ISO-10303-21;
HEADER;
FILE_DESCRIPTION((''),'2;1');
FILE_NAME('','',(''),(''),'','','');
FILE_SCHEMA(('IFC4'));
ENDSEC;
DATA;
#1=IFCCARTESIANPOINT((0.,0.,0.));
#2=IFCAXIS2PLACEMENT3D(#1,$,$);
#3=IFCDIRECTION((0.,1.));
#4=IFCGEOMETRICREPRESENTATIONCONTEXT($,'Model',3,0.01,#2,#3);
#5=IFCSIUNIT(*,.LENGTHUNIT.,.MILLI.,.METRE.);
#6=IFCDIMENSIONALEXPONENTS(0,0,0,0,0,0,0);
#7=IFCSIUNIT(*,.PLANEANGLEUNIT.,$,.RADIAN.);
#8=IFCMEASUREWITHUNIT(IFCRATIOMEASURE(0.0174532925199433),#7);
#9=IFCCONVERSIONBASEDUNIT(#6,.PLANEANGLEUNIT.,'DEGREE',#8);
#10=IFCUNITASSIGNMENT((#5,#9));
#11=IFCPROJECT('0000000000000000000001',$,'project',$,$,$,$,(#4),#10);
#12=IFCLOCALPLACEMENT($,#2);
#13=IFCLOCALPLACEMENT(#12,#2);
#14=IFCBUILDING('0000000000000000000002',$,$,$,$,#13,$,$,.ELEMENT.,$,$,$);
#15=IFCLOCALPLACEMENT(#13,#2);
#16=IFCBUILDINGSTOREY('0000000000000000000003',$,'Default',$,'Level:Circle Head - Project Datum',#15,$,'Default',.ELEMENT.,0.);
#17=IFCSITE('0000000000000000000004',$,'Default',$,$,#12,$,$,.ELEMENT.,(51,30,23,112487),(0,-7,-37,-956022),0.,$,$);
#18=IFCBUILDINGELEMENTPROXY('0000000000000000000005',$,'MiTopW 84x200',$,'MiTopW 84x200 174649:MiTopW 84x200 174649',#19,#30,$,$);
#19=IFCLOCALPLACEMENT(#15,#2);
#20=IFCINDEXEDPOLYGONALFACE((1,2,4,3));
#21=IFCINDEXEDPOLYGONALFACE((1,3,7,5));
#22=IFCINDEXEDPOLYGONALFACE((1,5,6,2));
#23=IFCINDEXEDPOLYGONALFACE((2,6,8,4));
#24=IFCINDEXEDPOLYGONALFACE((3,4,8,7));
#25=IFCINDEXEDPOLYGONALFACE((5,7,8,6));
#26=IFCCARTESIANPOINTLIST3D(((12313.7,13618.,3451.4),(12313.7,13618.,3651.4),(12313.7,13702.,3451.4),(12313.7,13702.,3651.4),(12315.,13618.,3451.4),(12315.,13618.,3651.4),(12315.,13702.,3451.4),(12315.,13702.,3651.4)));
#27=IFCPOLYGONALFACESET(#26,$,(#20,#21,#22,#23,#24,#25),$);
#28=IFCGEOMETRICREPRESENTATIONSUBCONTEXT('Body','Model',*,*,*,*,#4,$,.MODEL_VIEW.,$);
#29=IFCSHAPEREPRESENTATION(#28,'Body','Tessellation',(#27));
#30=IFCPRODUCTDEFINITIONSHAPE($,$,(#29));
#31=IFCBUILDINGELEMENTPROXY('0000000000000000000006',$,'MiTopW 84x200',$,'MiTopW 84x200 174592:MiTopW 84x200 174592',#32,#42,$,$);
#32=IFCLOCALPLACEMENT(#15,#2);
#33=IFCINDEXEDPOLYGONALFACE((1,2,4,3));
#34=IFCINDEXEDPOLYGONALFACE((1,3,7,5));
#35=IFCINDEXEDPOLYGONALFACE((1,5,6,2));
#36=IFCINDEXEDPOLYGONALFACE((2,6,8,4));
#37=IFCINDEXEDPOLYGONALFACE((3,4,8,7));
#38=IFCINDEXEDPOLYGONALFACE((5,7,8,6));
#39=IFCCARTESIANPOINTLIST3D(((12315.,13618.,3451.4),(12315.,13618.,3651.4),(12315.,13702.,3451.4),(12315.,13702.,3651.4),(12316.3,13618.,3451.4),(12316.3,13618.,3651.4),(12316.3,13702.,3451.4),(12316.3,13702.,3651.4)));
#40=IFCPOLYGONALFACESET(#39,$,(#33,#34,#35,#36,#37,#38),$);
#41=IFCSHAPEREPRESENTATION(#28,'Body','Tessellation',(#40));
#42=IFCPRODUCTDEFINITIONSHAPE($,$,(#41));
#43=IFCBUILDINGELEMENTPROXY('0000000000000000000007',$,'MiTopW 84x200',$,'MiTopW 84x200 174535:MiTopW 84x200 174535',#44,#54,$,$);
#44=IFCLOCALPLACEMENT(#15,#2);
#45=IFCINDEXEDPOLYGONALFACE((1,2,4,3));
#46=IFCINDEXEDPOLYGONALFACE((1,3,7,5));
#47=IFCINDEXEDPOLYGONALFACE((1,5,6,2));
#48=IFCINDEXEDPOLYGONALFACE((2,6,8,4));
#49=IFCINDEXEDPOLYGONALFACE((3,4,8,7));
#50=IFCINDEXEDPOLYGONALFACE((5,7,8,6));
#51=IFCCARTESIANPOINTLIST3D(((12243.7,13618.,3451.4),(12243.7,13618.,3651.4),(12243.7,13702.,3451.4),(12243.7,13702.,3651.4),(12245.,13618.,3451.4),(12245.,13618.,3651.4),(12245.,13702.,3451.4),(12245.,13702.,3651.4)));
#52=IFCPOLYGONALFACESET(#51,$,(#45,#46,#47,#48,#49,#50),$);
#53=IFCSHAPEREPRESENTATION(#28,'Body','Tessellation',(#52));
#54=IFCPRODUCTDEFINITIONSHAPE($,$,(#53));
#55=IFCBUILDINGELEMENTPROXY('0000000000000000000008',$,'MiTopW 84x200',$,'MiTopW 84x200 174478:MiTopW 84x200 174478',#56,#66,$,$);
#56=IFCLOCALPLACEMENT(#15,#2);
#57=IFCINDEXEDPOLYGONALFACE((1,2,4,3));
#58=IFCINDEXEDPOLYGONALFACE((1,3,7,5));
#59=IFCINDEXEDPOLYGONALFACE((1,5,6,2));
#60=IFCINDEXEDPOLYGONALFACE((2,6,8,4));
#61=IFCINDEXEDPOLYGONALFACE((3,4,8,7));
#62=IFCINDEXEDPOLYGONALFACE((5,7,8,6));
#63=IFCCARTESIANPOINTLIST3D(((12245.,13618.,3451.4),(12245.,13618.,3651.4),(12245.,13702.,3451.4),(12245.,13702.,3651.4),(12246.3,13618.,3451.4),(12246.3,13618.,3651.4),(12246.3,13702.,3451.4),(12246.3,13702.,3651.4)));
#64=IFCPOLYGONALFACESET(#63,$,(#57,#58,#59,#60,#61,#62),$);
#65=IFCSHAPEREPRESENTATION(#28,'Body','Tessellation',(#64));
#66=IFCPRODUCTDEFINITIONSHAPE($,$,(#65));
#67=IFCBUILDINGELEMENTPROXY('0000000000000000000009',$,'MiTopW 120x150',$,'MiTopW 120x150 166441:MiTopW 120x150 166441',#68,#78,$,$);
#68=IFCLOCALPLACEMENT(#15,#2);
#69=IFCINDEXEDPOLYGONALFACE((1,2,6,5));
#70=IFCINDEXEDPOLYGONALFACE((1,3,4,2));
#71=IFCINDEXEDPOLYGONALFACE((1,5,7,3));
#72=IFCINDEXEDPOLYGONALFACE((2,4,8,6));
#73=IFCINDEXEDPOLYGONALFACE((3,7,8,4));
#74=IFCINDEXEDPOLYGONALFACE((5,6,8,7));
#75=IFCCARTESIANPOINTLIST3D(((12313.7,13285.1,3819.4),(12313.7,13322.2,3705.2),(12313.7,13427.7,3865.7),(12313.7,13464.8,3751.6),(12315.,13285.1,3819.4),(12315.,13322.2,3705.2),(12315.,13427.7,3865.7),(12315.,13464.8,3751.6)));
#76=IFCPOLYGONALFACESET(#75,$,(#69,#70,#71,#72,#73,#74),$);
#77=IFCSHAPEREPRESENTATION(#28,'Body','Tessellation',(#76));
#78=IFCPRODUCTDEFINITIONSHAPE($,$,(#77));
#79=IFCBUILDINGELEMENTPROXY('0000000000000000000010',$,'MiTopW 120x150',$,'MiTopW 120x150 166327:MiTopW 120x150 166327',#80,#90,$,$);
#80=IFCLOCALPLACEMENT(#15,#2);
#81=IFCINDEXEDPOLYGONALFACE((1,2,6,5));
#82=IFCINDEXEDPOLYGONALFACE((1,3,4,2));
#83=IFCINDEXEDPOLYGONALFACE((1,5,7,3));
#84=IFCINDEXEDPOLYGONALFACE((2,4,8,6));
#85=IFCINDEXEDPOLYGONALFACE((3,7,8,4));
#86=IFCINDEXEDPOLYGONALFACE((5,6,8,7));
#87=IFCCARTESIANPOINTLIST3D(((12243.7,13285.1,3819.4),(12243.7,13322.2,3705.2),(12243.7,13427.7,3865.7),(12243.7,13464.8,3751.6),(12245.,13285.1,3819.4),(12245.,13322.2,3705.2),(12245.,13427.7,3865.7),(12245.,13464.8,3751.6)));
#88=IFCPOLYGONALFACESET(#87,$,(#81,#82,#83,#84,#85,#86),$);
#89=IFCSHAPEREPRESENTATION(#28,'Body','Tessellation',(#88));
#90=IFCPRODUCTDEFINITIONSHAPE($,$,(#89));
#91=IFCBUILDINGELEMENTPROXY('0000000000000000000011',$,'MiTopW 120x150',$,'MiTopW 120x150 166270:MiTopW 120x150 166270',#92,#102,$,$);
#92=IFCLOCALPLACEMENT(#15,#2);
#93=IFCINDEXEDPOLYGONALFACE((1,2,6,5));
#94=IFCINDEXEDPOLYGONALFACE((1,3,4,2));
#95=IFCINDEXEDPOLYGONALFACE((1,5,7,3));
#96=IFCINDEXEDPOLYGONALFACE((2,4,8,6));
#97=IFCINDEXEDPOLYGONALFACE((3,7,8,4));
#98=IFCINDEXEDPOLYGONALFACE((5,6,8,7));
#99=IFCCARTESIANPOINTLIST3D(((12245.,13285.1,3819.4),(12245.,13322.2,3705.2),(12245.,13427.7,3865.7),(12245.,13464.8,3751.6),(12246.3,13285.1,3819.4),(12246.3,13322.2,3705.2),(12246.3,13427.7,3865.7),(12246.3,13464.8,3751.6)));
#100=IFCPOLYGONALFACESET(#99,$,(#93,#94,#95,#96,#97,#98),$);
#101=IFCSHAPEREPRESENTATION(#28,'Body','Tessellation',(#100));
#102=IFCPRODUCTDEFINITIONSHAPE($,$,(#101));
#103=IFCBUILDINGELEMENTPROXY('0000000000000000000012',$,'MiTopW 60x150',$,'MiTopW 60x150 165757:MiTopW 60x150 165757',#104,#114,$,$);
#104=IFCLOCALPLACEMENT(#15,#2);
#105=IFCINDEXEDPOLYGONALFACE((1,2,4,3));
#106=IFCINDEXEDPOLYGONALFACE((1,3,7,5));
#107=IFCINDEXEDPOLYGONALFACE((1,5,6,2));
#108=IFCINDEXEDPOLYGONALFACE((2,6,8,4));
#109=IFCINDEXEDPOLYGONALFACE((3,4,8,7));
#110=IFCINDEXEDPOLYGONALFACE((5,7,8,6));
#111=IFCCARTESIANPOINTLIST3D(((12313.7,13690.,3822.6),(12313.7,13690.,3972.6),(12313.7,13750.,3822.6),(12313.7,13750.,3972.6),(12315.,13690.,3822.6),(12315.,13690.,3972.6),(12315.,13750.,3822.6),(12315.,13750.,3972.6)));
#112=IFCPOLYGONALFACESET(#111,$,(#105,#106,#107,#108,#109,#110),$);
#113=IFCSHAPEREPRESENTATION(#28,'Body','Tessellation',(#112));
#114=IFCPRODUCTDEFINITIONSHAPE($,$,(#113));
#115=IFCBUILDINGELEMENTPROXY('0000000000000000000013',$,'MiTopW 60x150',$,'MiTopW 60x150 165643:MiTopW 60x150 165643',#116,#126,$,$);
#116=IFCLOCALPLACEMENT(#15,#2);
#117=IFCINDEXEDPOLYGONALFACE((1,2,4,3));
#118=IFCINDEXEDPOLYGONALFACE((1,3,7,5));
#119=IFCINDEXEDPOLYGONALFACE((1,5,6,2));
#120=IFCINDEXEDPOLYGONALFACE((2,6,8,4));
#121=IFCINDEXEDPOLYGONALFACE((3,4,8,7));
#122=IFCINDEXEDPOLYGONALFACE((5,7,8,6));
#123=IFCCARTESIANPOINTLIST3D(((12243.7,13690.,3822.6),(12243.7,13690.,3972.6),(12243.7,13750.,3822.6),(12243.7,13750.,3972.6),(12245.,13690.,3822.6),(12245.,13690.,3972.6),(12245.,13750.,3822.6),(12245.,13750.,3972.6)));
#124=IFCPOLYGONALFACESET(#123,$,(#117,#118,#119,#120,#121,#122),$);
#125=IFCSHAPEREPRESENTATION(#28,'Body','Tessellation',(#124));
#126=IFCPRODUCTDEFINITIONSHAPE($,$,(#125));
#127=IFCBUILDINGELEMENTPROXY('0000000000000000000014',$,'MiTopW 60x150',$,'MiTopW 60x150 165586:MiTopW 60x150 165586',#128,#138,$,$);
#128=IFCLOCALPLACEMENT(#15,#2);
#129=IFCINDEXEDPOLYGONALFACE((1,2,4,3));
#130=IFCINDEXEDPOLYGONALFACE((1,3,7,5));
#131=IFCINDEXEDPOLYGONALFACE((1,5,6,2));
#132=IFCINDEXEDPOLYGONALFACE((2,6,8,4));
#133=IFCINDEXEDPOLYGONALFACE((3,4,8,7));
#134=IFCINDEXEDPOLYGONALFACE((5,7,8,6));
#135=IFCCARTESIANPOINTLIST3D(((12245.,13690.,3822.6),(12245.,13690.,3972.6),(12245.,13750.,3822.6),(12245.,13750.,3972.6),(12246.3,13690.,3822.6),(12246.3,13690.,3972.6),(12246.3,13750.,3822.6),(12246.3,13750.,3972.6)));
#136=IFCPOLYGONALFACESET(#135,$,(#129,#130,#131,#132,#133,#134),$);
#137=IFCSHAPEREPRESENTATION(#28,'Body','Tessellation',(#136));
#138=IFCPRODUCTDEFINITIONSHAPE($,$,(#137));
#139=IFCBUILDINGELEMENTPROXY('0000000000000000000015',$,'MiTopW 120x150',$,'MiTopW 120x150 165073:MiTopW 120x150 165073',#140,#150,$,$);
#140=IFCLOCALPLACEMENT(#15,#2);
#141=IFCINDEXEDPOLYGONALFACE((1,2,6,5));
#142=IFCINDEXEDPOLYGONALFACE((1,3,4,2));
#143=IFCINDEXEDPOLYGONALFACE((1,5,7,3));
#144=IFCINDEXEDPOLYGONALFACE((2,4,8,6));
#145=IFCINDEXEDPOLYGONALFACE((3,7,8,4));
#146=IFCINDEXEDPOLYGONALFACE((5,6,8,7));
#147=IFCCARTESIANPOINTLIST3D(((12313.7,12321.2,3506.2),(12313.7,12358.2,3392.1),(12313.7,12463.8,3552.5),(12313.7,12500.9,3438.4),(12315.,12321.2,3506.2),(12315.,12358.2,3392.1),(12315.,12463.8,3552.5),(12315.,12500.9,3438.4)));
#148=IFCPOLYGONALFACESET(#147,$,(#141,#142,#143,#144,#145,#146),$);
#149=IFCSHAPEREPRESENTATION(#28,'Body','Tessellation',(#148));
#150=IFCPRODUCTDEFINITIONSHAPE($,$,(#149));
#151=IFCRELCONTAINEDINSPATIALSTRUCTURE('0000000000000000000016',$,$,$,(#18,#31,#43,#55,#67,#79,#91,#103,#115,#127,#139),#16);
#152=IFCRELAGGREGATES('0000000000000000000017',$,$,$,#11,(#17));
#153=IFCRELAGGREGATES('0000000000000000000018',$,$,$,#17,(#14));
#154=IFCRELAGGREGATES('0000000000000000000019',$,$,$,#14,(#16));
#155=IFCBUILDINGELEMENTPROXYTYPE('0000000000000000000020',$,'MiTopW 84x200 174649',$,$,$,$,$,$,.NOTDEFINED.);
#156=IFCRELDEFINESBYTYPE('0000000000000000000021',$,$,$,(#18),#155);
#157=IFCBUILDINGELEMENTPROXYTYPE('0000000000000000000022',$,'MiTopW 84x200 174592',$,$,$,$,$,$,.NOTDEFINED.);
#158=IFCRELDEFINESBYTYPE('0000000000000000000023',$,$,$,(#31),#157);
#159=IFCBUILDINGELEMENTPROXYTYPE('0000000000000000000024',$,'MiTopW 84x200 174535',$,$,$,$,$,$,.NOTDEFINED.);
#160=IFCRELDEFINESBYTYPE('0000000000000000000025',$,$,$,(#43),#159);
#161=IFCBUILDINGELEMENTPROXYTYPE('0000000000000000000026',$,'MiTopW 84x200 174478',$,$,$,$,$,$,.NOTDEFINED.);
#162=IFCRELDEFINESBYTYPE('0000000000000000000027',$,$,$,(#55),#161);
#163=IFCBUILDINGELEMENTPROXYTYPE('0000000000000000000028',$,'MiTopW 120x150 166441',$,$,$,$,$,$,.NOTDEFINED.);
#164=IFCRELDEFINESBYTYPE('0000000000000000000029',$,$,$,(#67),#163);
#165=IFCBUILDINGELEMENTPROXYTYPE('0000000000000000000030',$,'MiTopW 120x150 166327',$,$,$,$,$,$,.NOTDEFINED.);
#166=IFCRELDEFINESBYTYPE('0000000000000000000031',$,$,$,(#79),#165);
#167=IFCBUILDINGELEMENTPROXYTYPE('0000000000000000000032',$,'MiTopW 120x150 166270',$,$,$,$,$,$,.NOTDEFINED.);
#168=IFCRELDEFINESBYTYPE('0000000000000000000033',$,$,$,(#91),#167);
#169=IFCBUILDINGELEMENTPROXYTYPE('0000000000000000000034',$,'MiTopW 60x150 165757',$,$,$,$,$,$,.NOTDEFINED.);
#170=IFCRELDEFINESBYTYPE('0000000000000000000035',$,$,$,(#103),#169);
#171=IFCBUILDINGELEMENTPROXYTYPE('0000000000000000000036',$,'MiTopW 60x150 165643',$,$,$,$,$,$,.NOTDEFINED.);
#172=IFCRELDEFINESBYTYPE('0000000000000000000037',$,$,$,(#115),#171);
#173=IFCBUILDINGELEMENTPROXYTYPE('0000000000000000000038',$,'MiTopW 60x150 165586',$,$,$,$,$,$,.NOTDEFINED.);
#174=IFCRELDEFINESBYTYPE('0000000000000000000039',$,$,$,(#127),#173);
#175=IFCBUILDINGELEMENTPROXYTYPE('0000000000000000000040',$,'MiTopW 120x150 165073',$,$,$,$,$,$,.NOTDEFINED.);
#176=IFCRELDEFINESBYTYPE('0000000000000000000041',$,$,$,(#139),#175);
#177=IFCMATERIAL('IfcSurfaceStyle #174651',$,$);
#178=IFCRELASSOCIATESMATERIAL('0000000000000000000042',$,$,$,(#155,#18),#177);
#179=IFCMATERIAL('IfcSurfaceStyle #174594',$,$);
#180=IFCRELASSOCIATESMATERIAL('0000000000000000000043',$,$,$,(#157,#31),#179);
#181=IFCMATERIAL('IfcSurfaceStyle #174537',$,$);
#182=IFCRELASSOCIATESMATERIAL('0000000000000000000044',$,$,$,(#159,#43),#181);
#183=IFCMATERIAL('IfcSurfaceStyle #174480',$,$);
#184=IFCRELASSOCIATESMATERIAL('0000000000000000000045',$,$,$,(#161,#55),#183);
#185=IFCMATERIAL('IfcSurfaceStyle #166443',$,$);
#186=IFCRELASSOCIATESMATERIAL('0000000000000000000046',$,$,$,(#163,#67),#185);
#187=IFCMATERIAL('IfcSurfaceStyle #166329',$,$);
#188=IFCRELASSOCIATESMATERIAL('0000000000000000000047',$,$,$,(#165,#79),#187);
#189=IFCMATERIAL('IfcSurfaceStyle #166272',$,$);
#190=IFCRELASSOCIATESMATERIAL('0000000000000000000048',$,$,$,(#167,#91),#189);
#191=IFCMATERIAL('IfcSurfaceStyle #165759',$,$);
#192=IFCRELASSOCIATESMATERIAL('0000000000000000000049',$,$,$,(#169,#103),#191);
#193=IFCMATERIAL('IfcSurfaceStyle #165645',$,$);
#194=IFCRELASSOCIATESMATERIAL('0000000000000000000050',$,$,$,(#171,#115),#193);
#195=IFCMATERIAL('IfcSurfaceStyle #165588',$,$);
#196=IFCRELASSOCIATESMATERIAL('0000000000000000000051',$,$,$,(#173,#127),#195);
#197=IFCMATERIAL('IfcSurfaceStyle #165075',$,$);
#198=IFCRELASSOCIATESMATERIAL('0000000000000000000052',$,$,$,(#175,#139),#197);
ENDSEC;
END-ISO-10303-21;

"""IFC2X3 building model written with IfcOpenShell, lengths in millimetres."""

from ifc_helpers import new_model, entity, si_unit, converted_unit, direction, frame, frame_2d, origin, origin_2d_with_axis, place, context, subcontext, project, spatial, polyline, rectangle, outline, extrude, source, transform, mapped, material, type_object, type_shapes, element, save


model = new_model("IFC2X3")

# Units and contexts
model_context = context("Model", 3, precision=0.01, world=origin(), true_north=direction((0.0, 1.0)))
body_context = subcontext(model_context, "Body", "Model", "MODEL_VIEW")
ifc_project = project(units=[si_unit("LENGTHUNIT", "METRE", prefix="MILLI"), converted_unit("PLANEANGLEUNIT", "DEGREE", entity("IfcRatioMeasure", 0.0174532925199433), si_unit("PLANEANGLEUNIT", "RADIAN"), dimensions=[0, 0, 0, 0, 0, 0, 0])], contexts=[model_context])

# Site, building, storey
site_placement = place(None, origin())
site = spatial("IfcSite", under=ifc_project, at=site_placement, Name="Default", CompositionType="ELEMENT", RefLatitude=(51, 30, 23, 112487), RefLongitude=(0, -7, -37, -956022), RefElevation=0.0)
building_placement = place(site_placement, origin())
building = spatial("IfcBuilding", under=site, at=building_placement, CompositionType="ELEMENT")
storey_placement = place(building_placement, origin())
storey = spatial("IfcBuildingStorey", under=building, at=storey_placement, Name="Default", ObjectType="Level:Circle Head - Project Datum", LongName="Default", CompositionType="ELEMENT", Elevation=0.0)

# Building element proxies
ifc_material_1 = material(Name="IfcSurfaceStyle #174651")
building_element_proxy_type_1 = type_object("IfcBuildingElementProxyType", Name="MiTopW 84x200 174649", PredefinedType="NOTDEFINED", material=ifc_material_1)
shared_shape_1 = source(origin(), body_context, "Body", "SweptSolid", [
    extrude(rectangle(XDim=200.0, YDim=84.0, at=frame_2d((0.0, 0.0), x_axis=(1.0, 0.0))), frame((100.0, 42.0, 0.0), z_axis=(0.0, 0.0, 1.0), x_axis=(-1.0, 0.0, 0.0)), (0.0, 0.0, 1.0), 1.3),
])
type_shapes(building_element_proxy_type_1, [shared_shape_1])
proxy_1_placement = place(building_placement, frame((12315.0, 13702.0, 3651.4), z_axis=(-1.0, 0.0, 0.0), x_axis=(0.0, 0.0, -1.0)))
element("IfcBuildingElementProxy", 1, at=proxy_1_placement, inside=storey, type_object=building_element_proxy_type_1, material=ifc_material_1, Name="MiTopW 84x200", ObjectType="MiTopW 84x200 174649:MiTopW 84x200 174649", context=body_context, shape_type="MappedRepresentation", body=[
    mapped(shared_shape_1, transform((0.0, 0.0, 0.0), scale=1.0)),
])
ifc_material_2 = material(Name="IfcSurfaceStyle #174594")
building_element_proxy_type_2 = type_object("IfcBuildingElementProxyType", Name="MiTopW 84x200 174592", PredefinedType="NOTDEFINED", material=ifc_material_2)
shared_shape_2 = source(origin(), body_context, "Body", "SweptSolid", [
    extrude(rectangle(XDim=200.0, YDim=84.0, at=frame_2d((0.0, 0.0), x_axis=(1.0, 0.0))), frame((100.0, 42.0, 0.0), z_axis=(0.0, 0.0, 1.0), x_axis=(-1.0, 0.0, 0.0)), (0.0, 0.0, 1.0), 1.3),
])
type_shapes(building_element_proxy_type_2, [shared_shape_2])
proxy_2_placement = place(building_placement, frame((12316.3, 13702.0, 3651.4), z_axis=(-1.0, 0.0, 0.0), x_axis=(0.0, 0.0, -1.0)))
element("IfcBuildingElementProxy", 2, at=proxy_2_placement, inside=storey, type_object=building_element_proxy_type_2, material=ifc_material_2, Name="MiTopW 84x200", ObjectType="MiTopW 84x200 174592:MiTopW 84x200 174592", context=body_context, shape_type="MappedRepresentation", body=[
    mapped(shared_shape_2, transform((0.0, 0.0, 0.0), scale=1.0)),
])
ifc_material_3 = material(Name="IfcSurfaceStyle #174537")
building_element_proxy_type_3 = type_object("IfcBuildingElementProxyType", Name="MiTopW 84x200 174535", PredefinedType="NOTDEFINED", material=ifc_material_3)
shared_shape_3 = source(origin(), body_context, "Body", "SweptSolid", [
    extrude(rectangle(XDim=200.0, YDim=84.0, at=frame_2d((0.0, 0.0), x_axis=(1.0, 0.0))), frame((100.0, 42.0, 0.0), z_axis=(0.0, 0.0, 1.0), x_axis=(-1.0, 0.0, 0.0)), (0.0, 0.0, 1.0), 1.3),
])
type_shapes(building_element_proxy_type_3, [shared_shape_3])
proxy_3_placement = place(building_placement, frame((12245.0, 13702.0, 3651.4), z_axis=(-1.0, 0.0, 0.0), x_axis=(0.0, 0.0, -1.0)))
element("IfcBuildingElementProxy", 3, at=proxy_3_placement, inside=storey, type_object=building_element_proxy_type_3, material=ifc_material_3, Name="MiTopW 84x200", ObjectType="MiTopW 84x200 174535:MiTopW 84x200 174535", context=body_context, shape_type="MappedRepresentation", body=[
    mapped(shared_shape_3, transform((0.0, 0.0, 0.0), scale=1.0)),
])
ifc_material_4 = material(Name="IfcSurfaceStyle #174480")
building_element_proxy_type_4 = type_object("IfcBuildingElementProxyType", Name="MiTopW 84x200 174478", PredefinedType="NOTDEFINED", material=ifc_material_4)
shared_shape_4 = source(origin(), body_context, "Body", "SweptSolid", [
    extrude(rectangle(XDim=200.0, YDim=84.0, at=frame_2d((0.0, 0.0), x_axis=(1.0, 0.0))), frame((100.0, 42.0, 0.0), z_axis=(0.0, 0.0, 1.0), x_axis=(-1.0, 0.0, 0.0)), (0.0, 0.0, 1.0), 1.3),
])
type_shapes(building_element_proxy_type_4, [shared_shape_4])
proxy_4_placement = place(building_placement, frame((12246.3, 13702.0, 3651.4), z_axis=(-1.0, 0.0, 0.0), x_axis=(0.0, 0.0, -1.0)))
element("IfcBuildingElementProxy", 4, at=proxy_4_placement, inside=storey, type_object=building_element_proxy_type_4, material=ifc_material_4, Name="MiTopW 84x200", ObjectType="MiTopW 84x200 174478:MiTopW 84x200 174478", context=body_context, shape_type="MappedRepresentation", body=[
    mapped(shared_shape_4, transform((0.0, 0.0, 0.0), scale=1.0)),
])
ifc_material_5 = material(Name="IfcSurfaceStyle #166443")
building_element_proxy_type_5 = type_object("IfcBuildingElementProxyType", Name="MiTopW 120x150 166441", PredefinedType="NOTDEFINED", material=ifc_material_5)
shared_shape_5 = source(origin(), body_context, "Body", "SweptSolid", [
    extrude(outline(polyline([(-75.0, -60.0), (75.0, -60.0), (75.0, 60.0), (-75.0, 60.0), (-75.0, -60.0)])), frame((75.0, 60.0, 0.0), z_axis=(0.0, 0.0, 1.0), x_axis=(-1.0, 0.0, 0.0)), (0.0, 0.0, 1.0), 1.3),
])
type_shapes(building_element_proxy_type_5, [shared_shape_5])
proxy_5_placement = place(building_placement, frame((12315.0, 13285.1, 3819.4), z_axis=(-1.0, 0.0, 0.0), x_axis=(0.0, 0.951057, 0.309017)))
element("IfcBuildingElementProxy", 5, at=proxy_5_placement, inside=storey, type_object=building_element_proxy_type_5, material=ifc_material_5, Name="MiTopW 120x150", ObjectType="MiTopW 120x150 166441:MiTopW 120x150 166441", context=body_context, shape_type="MappedRepresentation", body=[
    mapped(shared_shape_5, transform((0.0, 0.0, 0.0), scale=1.0)),
])
ifc_material_6 = material(Name="IfcSurfaceStyle #166329")
building_element_proxy_type_6 = type_object("IfcBuildingElementProxyType", Name="MiTopW 120x150 166327", PredefinedType="NOTDEFINED", material=ifc_material_6)
shared_shape_6 = source(origin(), body_context, "Body", "SweptSolid", [
    extrude(outline(polyline([(-75.0, -60.0), (75.0, -60.0), (75.0, 60.0), (-75.0, 60.0), (-75.0, -60.0)])), frame((75.0, 60.0, 0.0), z_axis=(0.0, 0.0, 1.0), x_axis=(-1.0, 0.0, 0.0)), (0.0, 0.0, 1.0), 1.3),
])
type_shapes(building_element_proxy_type_6, [shared_shape_6])
proxy_6_placement = place(building_placement, frame((12245.0, 13285.1, 3819.4), z_axis=(-1.0, 0.0, 0.0), x_axis=(0.0, 0.951057, 0.309017)))
element("IfcBuildingElementProxy", 6, at=proxy_6_placement, inside=storey, type_object=building_element_proxy_type_6, material=ifc_material_6, Name="MiTopW 120x150", ObjectType="MiTopW 120x150 166327:MiTopW 120x150 166327", context=body_context, shape_type="MappedRepresentation", body=[
    mapped(shared_shape_6, transform((0.0, 0.0, 0.0), scale=1.0)),
])
ifc_material_7 = material(Name="IfcSurfaceStyle #166272")
building_element_proxy_type_7 = type_object("IfcBuildingElementProxyType", Name="MiTopW 120x150 166270", PredefinedType="NOTDEFINED", material=ifc_material_7)
shared_shape_7 = source(origin(), body_context, "Body", "SweptSolid", [
    extrude(outline(polyline([(-75.0, -60.0), (75.0, -60.0), (75.0, 60.0), (-75.0, 60.0), (-75.0, -60.0)])), frame((75.0, 60.0, 0.0), z_axis=(0.0, 0.0, 1.0), x_axis=(-1.0, 0.0, 0.0)), (0.0, 0.0, 1.0), 1.3),
])
type_shapes(building_element_proxy_type_7, [shared_shape_7])
proxy_7_placement = place(building_placement, frame((12246.3, 13285.1, 3819.4), z_axis=(-1.0, 0.0, 0.0), x_axis=(0.0, 0.951057, 0.309017)))
element("IfcBuildingElementProxy", 7, at=proxy_7_placement, inside=storey, type_object=building_element_proxy_type_7, material=ifc_material_7, Name="MiTopW 120x150", ObjectType="MiTopW 120x150 166270:MiTopW 120x150 166270", context=body_context, shape_type="MappedRepresentation", body=[
    mapped(shared_shape_7, transform((0.0, 0.0, 0.0), scale=1.0)),
])
ifc_material_8 = material(Name="IfcSurfaceStyle #165759")
building_element_proxy_type_8 = type_object("IfcBuildingElementProxyType", Name="MiTopW 60x150 165757", PredefinedType="NOTDEFINED", material=ifc_material_8)
shared_shape_8 = source(origin(), body_context, "Body", "SweptSolid", [
    extrude(rectangle(XDim=150.0, YDim=60.0, at=origin_2d_with_axis()), frame((75.0, 30.0, 0.0), z_axis=(0.0, 0.0, 1.0), x_axis=(-1.0, 0.0, 0.0)), (0.0, 0.0, 1.0), 1.3),
])
type_shapes(building_element_proxy_type_8, [shared_shape_8])
proxy_8_placement = place(building_placement, frame((12315.0, 13750.0, 3972.6), z_axis=(-1.0, 0.0, 0.0), x_axis=(0.0, 0.0, -1.0)))
element("IfcBuildingElementProxy", 8, at=proxy_8_placement, inside=storey, type_object=building_element_proxy_type_8, material=ifc_material_8, Name="MiTopW 60x150", ObjectType="MiTopW 60x150 165757:MiTopW 60x150 165757", context=body_context, shape_type="MappedRepresentation", body=[
    mapped(shared_shape_8, transform((0.0, 0.0, 0.0), scale=1.0)),
])
ifc_material_9 = material(Name="IfcSurfaceStyle #165645")
building_element_proxy_type_9 = type_object("IfcBuildingElementProxyType", Name="MiTopW 60x150 165643", PredefinedType="NOTDEFINED", material=ifc_material_9)
shared_shape_9 = source(origin(), body_context, "Body", "SweptSolid", [
    extrude(rectangle(XDim=150.0, YDim=60.0, at=origin_2d_with_axis()), frame((75.0, 30.0, 0.0), z_axis=(0.0, 0.0, 1.0), x_axis=(-1.0, 0.0, 0.0)), (0.0, 0.0, 1.0), 1.3),
])
type_shapes(building_element_proxy_type_9, [shared_shape_9])
proxy_9_placement = place(building_placement, frame((12245.0, 13750.0, 3972.6), z_axis=(-1.0, 0.0, 0.0), x_axis=(0.0, 0.0, -1.0)))
element("IfcBuildingElementProxy", 9, at=proxy_9_placement, inside=storey, type_object=building_element_proxy_type_9, material=ifc_material_9, Name="MiTopW 60x150", ObjectType="MiTopW 60x150 165643:MiTopW 60x150 165643", context=body_context, shape_type="MappedRepresentation", body=[
    mapped(shared_shape_9, transform((0.0, 0.0, 0.0), scale=1.0)),
])
ifc_material_10 = material(Name="IfcSurfaceStyle #165588")
building_element_proxy_type_10 = type_object("IfcBuildingElementProxyType", Name="MiTopW 60x150 165586", PredefinedType="NOTDEFINED", material=ifc_material_10)
shared_shape_10 = source(origin(), body_context, "Body", "SweptSolid", [
    extrude(rectangle(XDim=150.0, YDim=60.0, at=origin_2d_with_axis()), frame((75.0, 30.0, 0.0), z_axis=(0.0, 0.0, 1.0), x_axis=(-1.0, 0.0, 0.0)), (0.0, 0.0, 1.0), 1.3),
])
type_shapes(building_element_proxy_type_10, [shared_shape_10])
proxy_10_placement = place(building_placement, frame((12246.3, 13750.0, 3972.6), z_axis=(-1.0, 0.0, 0.0), x_axis=(0.0, 0.0, -1.0)))
element("IfcBuildingElementProxy", 10, at=proxy_10_placement, inside=storey, type_object=building_element_proxy_type_10, material=ifc_material_10, Name="MiTopW 60x150", ObjectType="MiTopW 60x150 165586:MiTopW 60x150 165586", context=body_context, shape_type="MappedRepresentation", body=[
    mapped(shared_shape_10, transform((0.0, 0.0, 0.0), scale=1.0)),
])
ifc_material_11 = material(Name="IfcSurfaceStyle #165075")
building_element_proxy_type_11 = type_object("IfcBuildingElementProxyType", Name="MiTopW 120x150 165073", PredefinedType="NOTDEFINED", material=ifc_material_11)
shared_shape_11 = source(origin(), body_context, "Body", "SweptSolid", [
    extrude(outline(polyline([(-75.0, -60.0), (75.0, -60.0), (75.0, 60.0), (-75.0, 60.0), (-75.0, -60.0)])), frame((75.0, 60.0, 0.0), z_axis=(0.0, 0.0, 1.0), x_axis=(-1.0, 0.0, 0.0)), (0.0, 0.0, 1.0), 1.3),
])
type_shapes(building_element_proxy_type_11, [shared_shape_11])
proxy_11_placement = place(building_placement, frame((12315.0, 12321.2, 3506.2), z_axis=(-1.0, 0.0, 0.0), x_axis=(0.0, 0.951057, 0.309017)))
element("IfcBuildingElementProxy", 11, at=proxy_11_placement, inside=storey, type_object=building_element_proxy_type_11, material=ifc_material_11, Name="MiTopW 120x150", ObjectType="MiTopW 120x150 165073:MiTopW 120x150 165073", context=body_context, shape_type="MappedRepresentation", body=[
    mapped(shared_shape_11, transform((0.0, 0.0, 0.0), scale=1.0)),
])

save(model, "model.ifc")
